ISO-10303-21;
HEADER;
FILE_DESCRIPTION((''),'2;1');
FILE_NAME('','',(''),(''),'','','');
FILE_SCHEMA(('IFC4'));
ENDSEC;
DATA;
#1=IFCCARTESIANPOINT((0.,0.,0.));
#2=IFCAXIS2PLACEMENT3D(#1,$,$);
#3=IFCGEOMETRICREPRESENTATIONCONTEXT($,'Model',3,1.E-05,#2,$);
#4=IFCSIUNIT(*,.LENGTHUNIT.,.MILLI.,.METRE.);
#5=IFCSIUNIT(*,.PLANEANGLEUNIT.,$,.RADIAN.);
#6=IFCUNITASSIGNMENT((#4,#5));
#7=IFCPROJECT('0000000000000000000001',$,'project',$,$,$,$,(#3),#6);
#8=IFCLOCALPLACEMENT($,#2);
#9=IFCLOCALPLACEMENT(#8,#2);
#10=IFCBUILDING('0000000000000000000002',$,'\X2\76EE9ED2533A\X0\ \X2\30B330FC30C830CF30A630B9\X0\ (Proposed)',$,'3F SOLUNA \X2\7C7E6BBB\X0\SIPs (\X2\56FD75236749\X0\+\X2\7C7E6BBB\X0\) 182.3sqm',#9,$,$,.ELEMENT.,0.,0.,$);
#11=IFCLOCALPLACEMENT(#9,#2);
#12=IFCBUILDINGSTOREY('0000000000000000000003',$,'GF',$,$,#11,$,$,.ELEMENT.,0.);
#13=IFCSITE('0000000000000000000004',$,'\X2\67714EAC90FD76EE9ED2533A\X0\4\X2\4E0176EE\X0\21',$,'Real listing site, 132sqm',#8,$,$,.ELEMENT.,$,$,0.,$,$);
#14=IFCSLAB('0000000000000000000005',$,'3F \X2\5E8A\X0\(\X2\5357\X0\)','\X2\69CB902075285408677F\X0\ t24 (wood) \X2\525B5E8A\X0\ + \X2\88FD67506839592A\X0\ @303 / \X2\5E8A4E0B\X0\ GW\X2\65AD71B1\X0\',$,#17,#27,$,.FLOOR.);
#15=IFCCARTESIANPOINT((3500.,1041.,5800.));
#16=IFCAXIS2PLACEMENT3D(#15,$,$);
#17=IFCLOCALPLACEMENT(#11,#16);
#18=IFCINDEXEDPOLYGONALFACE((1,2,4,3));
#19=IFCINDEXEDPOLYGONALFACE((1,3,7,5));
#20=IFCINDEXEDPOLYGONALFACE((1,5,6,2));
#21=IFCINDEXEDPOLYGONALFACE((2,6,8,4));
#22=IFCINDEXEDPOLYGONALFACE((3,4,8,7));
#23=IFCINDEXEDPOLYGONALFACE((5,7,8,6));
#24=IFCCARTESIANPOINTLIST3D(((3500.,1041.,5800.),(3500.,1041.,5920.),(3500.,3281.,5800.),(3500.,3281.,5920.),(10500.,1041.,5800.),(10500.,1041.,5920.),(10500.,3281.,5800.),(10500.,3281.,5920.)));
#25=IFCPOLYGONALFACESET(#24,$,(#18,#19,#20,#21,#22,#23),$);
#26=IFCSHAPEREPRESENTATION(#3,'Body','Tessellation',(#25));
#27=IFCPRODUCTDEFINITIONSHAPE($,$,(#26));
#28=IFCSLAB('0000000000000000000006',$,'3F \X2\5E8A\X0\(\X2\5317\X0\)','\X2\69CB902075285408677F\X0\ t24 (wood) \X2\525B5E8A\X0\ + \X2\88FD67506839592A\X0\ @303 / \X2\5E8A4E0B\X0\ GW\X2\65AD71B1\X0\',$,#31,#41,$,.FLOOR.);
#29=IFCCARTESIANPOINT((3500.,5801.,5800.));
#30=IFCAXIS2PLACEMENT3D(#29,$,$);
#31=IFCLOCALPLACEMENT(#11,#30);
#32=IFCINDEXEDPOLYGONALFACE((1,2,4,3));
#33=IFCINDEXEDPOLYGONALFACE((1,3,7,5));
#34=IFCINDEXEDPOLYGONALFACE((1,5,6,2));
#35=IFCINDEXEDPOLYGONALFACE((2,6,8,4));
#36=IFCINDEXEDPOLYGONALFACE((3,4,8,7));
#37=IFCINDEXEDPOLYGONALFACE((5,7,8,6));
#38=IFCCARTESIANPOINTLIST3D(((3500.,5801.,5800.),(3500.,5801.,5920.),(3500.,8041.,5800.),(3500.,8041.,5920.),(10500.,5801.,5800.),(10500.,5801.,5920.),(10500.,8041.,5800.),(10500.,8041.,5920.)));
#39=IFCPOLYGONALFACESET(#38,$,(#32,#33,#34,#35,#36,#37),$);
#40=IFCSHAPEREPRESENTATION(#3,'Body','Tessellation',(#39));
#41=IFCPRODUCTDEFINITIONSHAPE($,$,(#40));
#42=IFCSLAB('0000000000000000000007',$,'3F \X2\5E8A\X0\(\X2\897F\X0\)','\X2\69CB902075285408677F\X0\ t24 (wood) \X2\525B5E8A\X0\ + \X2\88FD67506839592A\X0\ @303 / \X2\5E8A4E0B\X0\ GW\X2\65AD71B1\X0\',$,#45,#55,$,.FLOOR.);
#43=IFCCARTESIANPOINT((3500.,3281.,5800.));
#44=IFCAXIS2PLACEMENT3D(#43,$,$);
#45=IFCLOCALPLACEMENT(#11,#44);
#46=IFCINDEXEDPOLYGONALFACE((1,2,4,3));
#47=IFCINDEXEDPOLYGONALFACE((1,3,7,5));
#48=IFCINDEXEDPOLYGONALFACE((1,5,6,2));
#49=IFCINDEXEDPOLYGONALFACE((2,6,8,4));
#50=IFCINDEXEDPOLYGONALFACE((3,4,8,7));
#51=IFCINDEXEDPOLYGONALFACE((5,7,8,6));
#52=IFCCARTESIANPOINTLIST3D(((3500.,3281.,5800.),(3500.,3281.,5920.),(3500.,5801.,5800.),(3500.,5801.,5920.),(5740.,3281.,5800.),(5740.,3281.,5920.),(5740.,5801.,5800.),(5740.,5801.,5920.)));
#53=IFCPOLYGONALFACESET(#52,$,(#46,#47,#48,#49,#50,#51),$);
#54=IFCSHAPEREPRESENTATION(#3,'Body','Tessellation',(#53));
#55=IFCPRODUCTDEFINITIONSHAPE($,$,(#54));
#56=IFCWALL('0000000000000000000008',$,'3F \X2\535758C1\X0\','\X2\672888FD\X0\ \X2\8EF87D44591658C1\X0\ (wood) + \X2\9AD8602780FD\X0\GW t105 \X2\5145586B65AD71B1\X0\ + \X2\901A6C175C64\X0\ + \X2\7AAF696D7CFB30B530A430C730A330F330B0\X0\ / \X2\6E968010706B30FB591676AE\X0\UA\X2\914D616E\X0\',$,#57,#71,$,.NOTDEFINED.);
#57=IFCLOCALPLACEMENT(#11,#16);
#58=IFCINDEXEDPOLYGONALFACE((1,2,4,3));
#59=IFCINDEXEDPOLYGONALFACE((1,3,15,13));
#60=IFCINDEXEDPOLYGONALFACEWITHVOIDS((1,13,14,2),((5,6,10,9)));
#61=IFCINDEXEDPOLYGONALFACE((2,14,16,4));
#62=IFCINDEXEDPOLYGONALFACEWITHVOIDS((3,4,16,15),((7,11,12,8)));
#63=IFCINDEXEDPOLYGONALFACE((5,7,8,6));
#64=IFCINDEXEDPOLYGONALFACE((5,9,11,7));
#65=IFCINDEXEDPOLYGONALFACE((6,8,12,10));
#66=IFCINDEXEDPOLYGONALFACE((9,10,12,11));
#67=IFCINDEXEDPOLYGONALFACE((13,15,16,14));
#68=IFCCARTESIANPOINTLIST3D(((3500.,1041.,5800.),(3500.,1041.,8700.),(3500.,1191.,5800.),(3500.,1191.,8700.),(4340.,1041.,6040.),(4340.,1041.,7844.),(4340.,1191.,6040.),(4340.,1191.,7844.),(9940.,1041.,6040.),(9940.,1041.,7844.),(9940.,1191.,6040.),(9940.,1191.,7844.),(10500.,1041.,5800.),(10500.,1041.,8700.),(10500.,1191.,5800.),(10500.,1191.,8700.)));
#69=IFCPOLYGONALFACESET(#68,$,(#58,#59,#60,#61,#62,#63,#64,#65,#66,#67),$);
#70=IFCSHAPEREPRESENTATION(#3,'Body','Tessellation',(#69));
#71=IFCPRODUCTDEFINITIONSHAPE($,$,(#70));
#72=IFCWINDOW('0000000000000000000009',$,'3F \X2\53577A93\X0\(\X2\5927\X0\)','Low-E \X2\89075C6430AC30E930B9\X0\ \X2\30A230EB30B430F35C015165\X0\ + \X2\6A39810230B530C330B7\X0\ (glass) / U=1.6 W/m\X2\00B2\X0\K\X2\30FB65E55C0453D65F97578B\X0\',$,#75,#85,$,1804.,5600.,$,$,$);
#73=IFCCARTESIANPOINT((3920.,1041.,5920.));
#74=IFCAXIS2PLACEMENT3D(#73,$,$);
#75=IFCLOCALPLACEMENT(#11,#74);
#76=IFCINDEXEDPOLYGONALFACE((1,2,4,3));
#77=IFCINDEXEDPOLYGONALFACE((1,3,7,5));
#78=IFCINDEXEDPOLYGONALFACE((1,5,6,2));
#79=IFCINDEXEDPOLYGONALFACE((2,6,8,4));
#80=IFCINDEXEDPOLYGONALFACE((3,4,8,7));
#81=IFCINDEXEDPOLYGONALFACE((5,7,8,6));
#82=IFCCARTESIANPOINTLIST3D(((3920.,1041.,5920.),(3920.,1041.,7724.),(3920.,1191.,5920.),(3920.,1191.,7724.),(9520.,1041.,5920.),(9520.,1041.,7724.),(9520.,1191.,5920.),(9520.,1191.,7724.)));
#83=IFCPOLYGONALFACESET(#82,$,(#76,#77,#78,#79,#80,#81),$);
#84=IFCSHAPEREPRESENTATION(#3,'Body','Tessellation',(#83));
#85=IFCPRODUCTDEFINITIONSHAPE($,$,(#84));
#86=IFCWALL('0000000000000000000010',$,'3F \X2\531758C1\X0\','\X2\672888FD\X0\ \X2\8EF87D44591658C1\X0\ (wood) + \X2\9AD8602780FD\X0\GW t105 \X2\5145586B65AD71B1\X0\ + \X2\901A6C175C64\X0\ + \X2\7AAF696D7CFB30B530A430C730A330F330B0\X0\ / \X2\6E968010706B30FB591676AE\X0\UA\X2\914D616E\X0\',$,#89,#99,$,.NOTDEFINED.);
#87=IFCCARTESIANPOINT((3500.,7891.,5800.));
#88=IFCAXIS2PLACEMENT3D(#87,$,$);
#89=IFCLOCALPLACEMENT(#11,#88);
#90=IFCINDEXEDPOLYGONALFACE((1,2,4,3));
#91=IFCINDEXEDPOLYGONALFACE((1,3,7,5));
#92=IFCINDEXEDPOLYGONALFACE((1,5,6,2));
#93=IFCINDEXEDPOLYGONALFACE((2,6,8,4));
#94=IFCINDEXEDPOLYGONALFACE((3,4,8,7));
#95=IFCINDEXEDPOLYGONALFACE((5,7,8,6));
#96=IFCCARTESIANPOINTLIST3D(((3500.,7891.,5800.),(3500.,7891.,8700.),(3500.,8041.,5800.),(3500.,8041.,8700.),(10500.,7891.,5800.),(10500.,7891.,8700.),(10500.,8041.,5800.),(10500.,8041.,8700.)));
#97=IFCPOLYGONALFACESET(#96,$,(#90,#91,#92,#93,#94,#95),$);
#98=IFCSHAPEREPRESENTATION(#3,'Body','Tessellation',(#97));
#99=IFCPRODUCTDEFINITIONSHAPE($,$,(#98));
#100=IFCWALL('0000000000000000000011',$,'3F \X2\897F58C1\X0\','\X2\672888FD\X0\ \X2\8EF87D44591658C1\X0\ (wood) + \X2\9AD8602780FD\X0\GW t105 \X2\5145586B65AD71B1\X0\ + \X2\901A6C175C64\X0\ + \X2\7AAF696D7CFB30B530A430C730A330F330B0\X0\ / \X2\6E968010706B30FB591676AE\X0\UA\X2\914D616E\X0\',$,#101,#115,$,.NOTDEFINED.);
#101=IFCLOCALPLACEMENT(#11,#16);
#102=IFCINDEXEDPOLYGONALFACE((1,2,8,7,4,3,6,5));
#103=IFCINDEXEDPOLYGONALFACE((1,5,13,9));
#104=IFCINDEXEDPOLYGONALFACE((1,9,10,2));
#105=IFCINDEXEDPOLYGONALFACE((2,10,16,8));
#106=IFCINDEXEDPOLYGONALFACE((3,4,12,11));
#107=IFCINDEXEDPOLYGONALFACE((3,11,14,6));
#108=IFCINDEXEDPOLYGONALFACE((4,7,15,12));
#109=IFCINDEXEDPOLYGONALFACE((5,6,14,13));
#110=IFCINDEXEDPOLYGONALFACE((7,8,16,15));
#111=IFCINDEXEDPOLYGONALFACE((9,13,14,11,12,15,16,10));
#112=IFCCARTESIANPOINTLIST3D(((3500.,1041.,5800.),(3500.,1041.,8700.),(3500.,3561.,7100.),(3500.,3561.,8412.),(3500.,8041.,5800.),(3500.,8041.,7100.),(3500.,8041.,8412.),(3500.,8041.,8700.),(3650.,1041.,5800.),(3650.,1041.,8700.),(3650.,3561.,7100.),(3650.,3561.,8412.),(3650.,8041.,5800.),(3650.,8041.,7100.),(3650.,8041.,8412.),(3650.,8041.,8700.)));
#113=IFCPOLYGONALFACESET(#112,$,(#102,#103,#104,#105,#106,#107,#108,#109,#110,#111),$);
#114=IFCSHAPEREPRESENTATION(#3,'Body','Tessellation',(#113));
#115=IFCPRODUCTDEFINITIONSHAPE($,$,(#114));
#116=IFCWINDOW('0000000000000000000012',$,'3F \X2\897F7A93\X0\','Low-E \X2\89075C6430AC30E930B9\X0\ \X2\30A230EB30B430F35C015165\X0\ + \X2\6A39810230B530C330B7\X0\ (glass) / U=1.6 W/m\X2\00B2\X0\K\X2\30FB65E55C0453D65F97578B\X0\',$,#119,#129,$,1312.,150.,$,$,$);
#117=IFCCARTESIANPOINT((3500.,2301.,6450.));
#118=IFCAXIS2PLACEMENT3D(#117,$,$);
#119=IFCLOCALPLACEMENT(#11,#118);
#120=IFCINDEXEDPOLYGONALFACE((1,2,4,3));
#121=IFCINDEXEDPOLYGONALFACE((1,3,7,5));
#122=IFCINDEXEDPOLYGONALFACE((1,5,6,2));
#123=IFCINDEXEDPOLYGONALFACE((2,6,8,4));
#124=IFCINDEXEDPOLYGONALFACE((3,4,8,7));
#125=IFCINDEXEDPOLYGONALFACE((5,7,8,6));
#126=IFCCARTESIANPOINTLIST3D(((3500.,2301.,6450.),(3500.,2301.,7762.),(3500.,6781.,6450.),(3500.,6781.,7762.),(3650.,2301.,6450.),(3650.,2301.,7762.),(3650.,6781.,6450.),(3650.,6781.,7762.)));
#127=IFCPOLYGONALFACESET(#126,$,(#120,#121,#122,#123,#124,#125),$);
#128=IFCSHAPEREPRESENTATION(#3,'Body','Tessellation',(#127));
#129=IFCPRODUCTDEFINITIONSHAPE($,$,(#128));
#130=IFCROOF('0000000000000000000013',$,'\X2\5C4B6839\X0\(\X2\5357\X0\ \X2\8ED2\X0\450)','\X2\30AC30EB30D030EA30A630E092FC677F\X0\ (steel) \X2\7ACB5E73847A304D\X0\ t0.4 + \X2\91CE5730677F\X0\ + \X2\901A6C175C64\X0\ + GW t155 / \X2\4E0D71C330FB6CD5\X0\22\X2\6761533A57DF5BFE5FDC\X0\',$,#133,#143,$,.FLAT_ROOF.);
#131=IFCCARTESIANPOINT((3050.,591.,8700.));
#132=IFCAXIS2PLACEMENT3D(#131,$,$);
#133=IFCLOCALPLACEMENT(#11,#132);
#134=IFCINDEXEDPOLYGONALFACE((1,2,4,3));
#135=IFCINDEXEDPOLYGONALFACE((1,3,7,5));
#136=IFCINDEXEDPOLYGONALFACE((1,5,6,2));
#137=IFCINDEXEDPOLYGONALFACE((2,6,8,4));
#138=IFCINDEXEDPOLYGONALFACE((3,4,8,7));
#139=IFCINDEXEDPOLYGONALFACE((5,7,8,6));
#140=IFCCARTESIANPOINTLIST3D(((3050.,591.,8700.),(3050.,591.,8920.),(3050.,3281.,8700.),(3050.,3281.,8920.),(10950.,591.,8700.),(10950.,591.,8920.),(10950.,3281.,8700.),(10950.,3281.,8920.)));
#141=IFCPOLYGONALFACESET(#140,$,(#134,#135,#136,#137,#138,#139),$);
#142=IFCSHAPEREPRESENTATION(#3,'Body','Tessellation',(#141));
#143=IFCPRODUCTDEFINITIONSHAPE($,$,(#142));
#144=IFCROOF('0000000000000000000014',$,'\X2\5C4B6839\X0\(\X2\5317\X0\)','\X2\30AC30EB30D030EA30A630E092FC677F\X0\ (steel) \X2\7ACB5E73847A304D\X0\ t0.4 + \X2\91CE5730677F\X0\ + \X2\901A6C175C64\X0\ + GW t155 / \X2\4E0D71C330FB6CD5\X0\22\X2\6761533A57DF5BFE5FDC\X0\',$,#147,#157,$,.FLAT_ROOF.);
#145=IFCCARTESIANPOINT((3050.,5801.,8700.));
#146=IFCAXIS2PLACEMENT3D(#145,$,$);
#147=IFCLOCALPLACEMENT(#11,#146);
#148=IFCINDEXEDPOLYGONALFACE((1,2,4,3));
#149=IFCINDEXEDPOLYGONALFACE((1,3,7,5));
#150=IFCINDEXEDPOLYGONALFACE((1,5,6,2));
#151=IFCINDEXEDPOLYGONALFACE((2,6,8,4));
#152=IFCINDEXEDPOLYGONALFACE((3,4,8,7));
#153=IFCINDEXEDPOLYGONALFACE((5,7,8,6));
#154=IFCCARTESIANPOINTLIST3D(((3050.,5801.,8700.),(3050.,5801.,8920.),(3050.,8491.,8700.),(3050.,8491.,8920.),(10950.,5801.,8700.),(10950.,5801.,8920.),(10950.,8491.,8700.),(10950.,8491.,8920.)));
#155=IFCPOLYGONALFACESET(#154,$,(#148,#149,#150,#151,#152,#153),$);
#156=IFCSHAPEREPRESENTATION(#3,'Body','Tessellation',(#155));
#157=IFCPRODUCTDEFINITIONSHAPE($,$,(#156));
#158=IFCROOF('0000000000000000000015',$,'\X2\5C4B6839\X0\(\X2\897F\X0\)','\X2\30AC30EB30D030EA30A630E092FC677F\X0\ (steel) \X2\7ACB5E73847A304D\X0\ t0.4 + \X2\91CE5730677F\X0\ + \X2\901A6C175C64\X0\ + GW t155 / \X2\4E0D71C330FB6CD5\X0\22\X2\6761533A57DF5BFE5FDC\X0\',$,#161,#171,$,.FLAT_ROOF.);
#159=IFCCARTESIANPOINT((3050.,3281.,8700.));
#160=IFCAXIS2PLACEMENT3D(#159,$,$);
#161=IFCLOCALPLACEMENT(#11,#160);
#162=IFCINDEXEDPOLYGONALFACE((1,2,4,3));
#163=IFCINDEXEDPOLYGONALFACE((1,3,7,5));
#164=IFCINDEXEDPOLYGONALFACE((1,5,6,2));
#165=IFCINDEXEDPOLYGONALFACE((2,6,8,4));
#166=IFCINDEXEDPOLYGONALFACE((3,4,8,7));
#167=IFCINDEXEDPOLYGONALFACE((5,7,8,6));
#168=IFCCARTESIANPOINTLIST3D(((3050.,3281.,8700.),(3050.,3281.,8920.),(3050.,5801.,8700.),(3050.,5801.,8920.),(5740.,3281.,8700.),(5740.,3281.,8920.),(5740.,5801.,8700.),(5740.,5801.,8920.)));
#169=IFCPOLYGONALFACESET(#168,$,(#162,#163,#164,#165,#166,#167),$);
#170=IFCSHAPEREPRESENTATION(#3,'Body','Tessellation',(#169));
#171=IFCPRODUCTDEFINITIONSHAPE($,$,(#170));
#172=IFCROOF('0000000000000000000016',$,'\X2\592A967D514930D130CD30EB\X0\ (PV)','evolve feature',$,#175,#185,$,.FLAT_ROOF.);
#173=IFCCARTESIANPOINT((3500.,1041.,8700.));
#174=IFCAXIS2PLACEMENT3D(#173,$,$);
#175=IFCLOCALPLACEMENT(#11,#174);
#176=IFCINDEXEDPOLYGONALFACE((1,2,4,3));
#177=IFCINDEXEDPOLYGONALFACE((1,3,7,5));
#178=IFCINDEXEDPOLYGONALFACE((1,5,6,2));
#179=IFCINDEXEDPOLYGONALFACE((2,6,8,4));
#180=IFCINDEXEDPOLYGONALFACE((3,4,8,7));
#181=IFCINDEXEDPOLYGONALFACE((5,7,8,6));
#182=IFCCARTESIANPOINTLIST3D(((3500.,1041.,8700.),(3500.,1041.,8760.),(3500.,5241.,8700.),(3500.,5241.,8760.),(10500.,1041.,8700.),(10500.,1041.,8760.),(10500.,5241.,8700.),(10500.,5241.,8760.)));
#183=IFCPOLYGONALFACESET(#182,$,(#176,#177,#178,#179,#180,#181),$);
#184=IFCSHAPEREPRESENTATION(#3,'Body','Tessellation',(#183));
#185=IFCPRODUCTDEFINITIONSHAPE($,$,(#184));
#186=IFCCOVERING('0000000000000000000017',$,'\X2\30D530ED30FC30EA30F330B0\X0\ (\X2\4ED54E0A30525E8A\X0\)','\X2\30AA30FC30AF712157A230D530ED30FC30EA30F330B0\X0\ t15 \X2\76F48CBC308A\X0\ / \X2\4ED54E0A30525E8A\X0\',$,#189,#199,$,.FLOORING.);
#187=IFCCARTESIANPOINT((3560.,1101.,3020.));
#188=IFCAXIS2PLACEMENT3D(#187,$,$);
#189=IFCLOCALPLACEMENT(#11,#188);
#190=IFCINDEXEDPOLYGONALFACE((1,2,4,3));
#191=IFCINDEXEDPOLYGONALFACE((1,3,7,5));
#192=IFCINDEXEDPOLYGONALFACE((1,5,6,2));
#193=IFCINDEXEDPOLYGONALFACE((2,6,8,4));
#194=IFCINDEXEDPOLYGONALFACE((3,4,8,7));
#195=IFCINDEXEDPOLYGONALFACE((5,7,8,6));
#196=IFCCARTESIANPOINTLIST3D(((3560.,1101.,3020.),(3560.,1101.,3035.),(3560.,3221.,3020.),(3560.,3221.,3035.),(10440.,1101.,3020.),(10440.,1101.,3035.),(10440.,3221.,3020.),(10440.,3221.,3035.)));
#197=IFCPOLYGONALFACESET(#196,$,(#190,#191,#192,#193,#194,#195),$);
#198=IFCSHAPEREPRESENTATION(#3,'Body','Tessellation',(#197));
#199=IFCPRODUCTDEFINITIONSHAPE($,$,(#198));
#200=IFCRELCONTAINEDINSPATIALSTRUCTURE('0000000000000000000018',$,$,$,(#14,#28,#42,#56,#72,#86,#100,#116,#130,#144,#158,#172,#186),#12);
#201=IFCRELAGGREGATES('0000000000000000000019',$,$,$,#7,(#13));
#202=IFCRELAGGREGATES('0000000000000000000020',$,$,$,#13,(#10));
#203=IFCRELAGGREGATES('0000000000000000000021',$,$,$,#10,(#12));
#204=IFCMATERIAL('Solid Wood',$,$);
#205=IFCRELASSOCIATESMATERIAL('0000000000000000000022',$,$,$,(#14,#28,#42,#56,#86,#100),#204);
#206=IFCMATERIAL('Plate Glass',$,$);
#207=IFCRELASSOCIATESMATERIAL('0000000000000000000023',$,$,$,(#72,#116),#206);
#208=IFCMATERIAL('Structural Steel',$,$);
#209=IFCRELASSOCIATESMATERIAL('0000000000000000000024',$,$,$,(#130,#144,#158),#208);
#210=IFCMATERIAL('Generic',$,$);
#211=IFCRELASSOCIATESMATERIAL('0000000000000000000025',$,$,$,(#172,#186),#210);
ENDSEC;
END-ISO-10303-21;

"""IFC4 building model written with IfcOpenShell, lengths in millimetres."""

from ifc_helpers import new_model, si_unit, frame, frame_2d, origin, place, context, project, spatial, rectangle, extrude, material, element, fill, save


model = new_model("IFC4")

# Units and contexts
model_context = context("Model", 3, precision=1e-05, world=origin())
ifc_project = project(units=[si_unit("LENGTHUNIT", "METRE", prefix="MILLI"), si_unit("PLANEANGLEUNIT", "RADIAN")], contexts=[model_context])

# Site, building, storey
site_placement = place(None, origin())
site = spatial("IfcSite", under=ifc_project, at=site_placement, Name="東京都目黒区4丁目21", ObjectType="Real listing site, 132sqm", CompositionType="ELEMENT", RefElevation=0.0)
building_placement = place(site_placement, origin())
building = spatial("IfcBuilding", under=site, at=building_placement, Name="目黒区 コートハウス (Proposed)", ObjectType="3F SOLUNA 籾殻SIPs (国産杉+籾殻) 182.3sqm", CompositionType="ELEMENT", ElevationOfRefHeight=0.0, ElevationOfTerrain=0.0)
storey_placement = place(building_placement, origin())
storey = spatial("IfcBuildingStorey", under=building, at=storey_placement, Name="GF", CompositionType="ELEMENT", Elevation=0.0)

# Slabs
ifc_material_1 = material(Name="Solid Wood")
slab_1_placement = place(storey_placement, frame((3500.0, 1041.0, 5800.0)))
element("IfcSlab", 1, at=slab_1_placement, inside=storey, material=ifc_material_1, Name="3F 床(南)", Description="構造用合板 t24 (wood) 剛床 + 製材根太 @303 / 床下 GW断熱", PredefinedType="FLOOR", context=model_context, shape_type="SweptSolid", body=[
    extrude(rectangle(XDim=7000.0, YDim=2240.0, at=frame_2d((3500.0, 1120.0))), frame((3500.0, 1041.0, 5800.0)), (0.0, 0.0, 1.0), 120.0),
])
slab_2_placement = place(storey_placement, frame((3500.0, 5801.0, 5800.0)))
element("IfcSlab", 2, at=slab_2_placement, inside=storey, material=ifc_material_1, Name="3F 床(北)", Description="構造用合板 t24 (wood) 剛床 + 製材根太 @303 / 床下 GW断熱", PredefinedType="FLOOR", context=model_context, shape_type="SweptSolid", body=[
    extrude(rectangle(XDim=7000.0, YDim=2240.0, at=frame_2d((3500.0, 1120.0))), frame((3500.0, 5801.0, 5800.0)), (0.0, 0.0, 1.0), 120.0),
])
slab_3_placement = place(storey_placement, frame((3500.0, 3281.0, 5800.0)))
element("IfcSlab", 3, at=slab_3_placement, inside=storey, material=ifc_material_1, Name="3F 床(西)", Description="構造用合板 t24 (wood) 剛床 + 製材根太 @303 / 床下 GW断熱", PredefinedType="FLOOR", context=model_context, shape_type="SweptSolid", body=[
    extrude(rectangle(XDim=2240.0, YDim=2520.0, at=frame_2d((1120.0, 1260.0))), frame((3500.0, 3281.0, 5800.0)), (0.0, 0.0, 1.0), 120.0),
])

# Wall, opening, window
wall_1_placement = place(storey_placement, frame((3500.0, 1041.0, 5800.0)))
wall_1 = element("IfcWall", 4, at=wall_1_placement, inside=storey, material=ifc_material_1, Name="3F 南壁", Description="木製 軸組外壁 (wood) + 高性能GW t105 充填断熱 + 通気層 + 窯業系サイディング / 準耐火・外皮UA配慮", PredefinedType="NOTDEFINED", context=model_context, shape_type="SweptSolid", body=[
    extrude(rectangle(XDim=7000.0, YDim=150.0, at=frame_2d((3500.0, 75.0))), frame((3500.0, 1041.0, 5800.0)), (0.0, 0.0, 1.0), 2900.0),
])
opening_1_placement = place(storey_placement, frame((3920.0, 1041.0, 5920.0)))
opening_1 = element("IfcOpeningElement", 5, at=opening_1_placement, cuts=wall_1, PredefinedType="NOTDEFINED", context=model_context, shape_type="SweptSolid", body=[
    extrude(rectangle(XDim=5600.0, YDim=150.0, at=frame_2d((2800.0, 75.0))), frame((3920.0, 1041.0, 5920.0)), (0.0, 0.0, 1.0), 1804.0),
])
ifc_material_2 = material(Name="Plate Glass")
window_1_placement = place(storey_placement, frame((3920.0, 1041.0, 5920.0)))
window_1 = element("IfcWindow", 6, at=window_1_placement, inside=storey, material=ifc_material_2, Name="3F 南窓(大)", Description="Low-E 複層ガラス アルゴン封入 + 樹脂サッシ (glass) / U=1.6 W/m²K・日射取得型", OverallHeight=1804.0, OverallWidth=5600.0, context=model_context, shape_type="SweptSolid", body=[
    extrude(rectangle(XDim=5600.0, YDim=150.0, at=frame_2d((2800.0, 75.0))), frame((3920.0, 1041.0, 5920.0)), (0.0, 0.0, 1.0), 1804.0),
])
fill(opening_1, window_1)

# Wall
wall_2_placement = place(storey_placement, frame((3500.0, 7891.0, 5800.0)))
element("IfcWall", 7, at=wall_2_placement, inside=storey, material=ifc_material_1, Name="3F 北壁", Description="木製 軸組外壁 (wood) + 高性能GW t105 充填断熱 + 通気層 + 窯業系サイディング / 準耐火・外皮UA配慮", PredefinedType="NOTDEFINED", context=model_context, shape_type="SweptSolid", body=[
    extrude(rectangle(XDim=7000.0, YDim=150.0, at=frame_2d((3500.0, 75.0))), frame((3500.0, 7891.0, 5800.0)), (0.0, 0.0, 1.0), 2900.0),
])

# Wall, opening, window
wall_3_placement = place(storey_placement, frame((3500.0, 1041.0, 5800.0)))
wall_3 = element("IfcWall", 8, at=wall_3_placement, inside=storey, material=ifc_material_1, Name="3F 西壁", Description="木製 軸組外壁 (wood) + 高性能GW t105 充填断熱 + 通気層 + 窯業系サイディング / 準耐火・外皮UA配慮", PredefinedType="NOTDEFINED", context=model_context, shape_type="SweptSolid", body=[
    extrude(rectangle(XDim=150.0, YDim=7000.0, at=frame_2d((75.0, 3500.0))), frame((3500.0, 1041.0, 5800.0)), (0.0, 0.0, 1.0), 2900.0),
])
opening_2_placement = place(storey_placement, frame((3500.0, 2301.0, 6450.0)))
opening_2 = element("IfcOpeningElement", 9, at=opening_2_placement, cuts=wall_3, PredefinedType="NOTDEFINED", context=model_context, shape_type="SweptSolid", body=[
    extrude(rectangle(XDim=150.0, YDim=4480.0, at=frame_2d((75.0, 2240.0))), frame((3500.0, 2301.0, 6450.0)), (0.0, 0.0, 1.0), 1312.0),
])
window_2_placement = place(storey_placement, frame((3500.0, 2301.0, 6450.0)))
window_2 = element("IfcWindow", 10, at=window_2_placement, inside=storey, material=ifc_material_2, Name="3F 西窓", Description="Low-E 複層ガラス アルゴン封入 + 樹脂サッシ (glass) / U=1.6 W/m²K・日射取得型", OverallHeight=1312.0, OverallWidth=150.0, context=model_context, shape_type="SweptSolid", body=[
    extrude(rectangle(XDim=150.0, YDim=4480.0, at=frame_2d((75.0, 2240.0))), frame((3500.0, 2301.0, 6450.0)), (0.0, 0.0, 1.0), 1312.0),
])
fill(opening_2, window_2)

# Roofs
ifc_material_3 = material(Name="Structural Steel")
roof_1_placement = place(storey_placement, frame((3050.0, 591.0, 8700.0)))
element("IfcRoof", 11, at=roof_1_placement, inside=storey, material=ifc_material_3, Name="屋根(南 軒450)", Description="ガルバリウム鋼板 (steel) 立平葺き t0.4 + 野地板 + 通気層 + GW t155 / 不燃・法22条区域対応", PredefinedType="FLAT_ROOF", context=model_context, shape_type="SweptSolid", body=[
    extrude(rectangle(XDim=7900.0, YDim=2690.0, at=frame_2d((3950.0, 1345.0))), frame((3050.0, 591.0, 8700.0)), (0.0, 0.0, 1.0), 220.0),
])
roof_2_placement = place(storey_placement, frame((3050.0, 5801.0, 8700.0)))
element("IfcRoof", 12, at=roof_2_placement, inside=storey, material=ifc_material_3, Name="屋根(北)", Description="ガルバリウム鋼板 (steel) 立平葺き t0.4 + 野地板 + 通気層 + GW t155 / 不燃・法22条区域対応", PredefinedType="FLAT_ROOF", context=model_context, shape_type="SweptSolid", body=[
    extrude(rectangle(XDim=7900.0, YDim=2690.0, at=frame_2d((3950.0, 1345.0))), frame((3050.0, 5801.0, 8700.0)), (0.0, 0.0, 1.0), 220.0),
])
roof_3_placement = place(storey_placement, frame((3050.0, 3281.0, 8700.0)))
element("IfcRoof", 13, at=roof_3_placement, inside=storey, material=ifc_material_3, Name="屋根(西)", Description="ガルバリウム鋼板 (steel) 立平葺き t0.4 + 野地板 + 通気層 + GW t155 / 不燃・法22条区域対応", PredefinedType="FLAT_ROOF", context=model_context, shape_type="SweptSolid", body=[
    extrude(rectangle(XDim=2690.0, YDim=2520.0, at=frame_2d((1345.0, 1260.0))), frame((3050.0, 3281.0, 8700.0)), (0.0, 0.0, 1.0), 220.0),
])
ifc_material_4 = material(Name="Generic")
roof_4_placement = place(storey_placement, frame((3500.0, 1041.0, 8700.0)))
element("IfcRoof", 14, at=roof_4_placement, inside=storey, material=ifc_material_4, Name="太陽光パネル (PV)", Description="evolve feature", PredefinedType="FLAT_ROOF", context=model_context, shape_type="SweptSolid", body=[
    extrude(rectangle(XDim=7000.0, YDim=4200.0, at=frame_2d((3500.0, 2100.0))), frame((3500.0, 1041.0, 8700.0)), (0.0, 0.0, 1.0), 60.0),
])

# Covering
covering_1_placement = place(storey_placement, frame((3560.0, 1101.0, 3020.0)))
element("IfcCovering", 15, at=covering_1_placement, inside=storey, material=ifc_material_4, Name="フローリング (仕上げ床)", Description="オーク無垢フローリング t15 直貼り / 仕上げ床", PredefinedType="FLOORING", context=model_context, shape_type="SweptSolid", body=[
    extrude(rectangle(XDim=6880.0, YDim=2120.0, at=frame_2d((3440.0, 1060.0))), frame((3560.0, 1101.0, 3020.0)), (0.0, 0.0, 1.0), 15.0),
])

save(model, "model.ifc")
